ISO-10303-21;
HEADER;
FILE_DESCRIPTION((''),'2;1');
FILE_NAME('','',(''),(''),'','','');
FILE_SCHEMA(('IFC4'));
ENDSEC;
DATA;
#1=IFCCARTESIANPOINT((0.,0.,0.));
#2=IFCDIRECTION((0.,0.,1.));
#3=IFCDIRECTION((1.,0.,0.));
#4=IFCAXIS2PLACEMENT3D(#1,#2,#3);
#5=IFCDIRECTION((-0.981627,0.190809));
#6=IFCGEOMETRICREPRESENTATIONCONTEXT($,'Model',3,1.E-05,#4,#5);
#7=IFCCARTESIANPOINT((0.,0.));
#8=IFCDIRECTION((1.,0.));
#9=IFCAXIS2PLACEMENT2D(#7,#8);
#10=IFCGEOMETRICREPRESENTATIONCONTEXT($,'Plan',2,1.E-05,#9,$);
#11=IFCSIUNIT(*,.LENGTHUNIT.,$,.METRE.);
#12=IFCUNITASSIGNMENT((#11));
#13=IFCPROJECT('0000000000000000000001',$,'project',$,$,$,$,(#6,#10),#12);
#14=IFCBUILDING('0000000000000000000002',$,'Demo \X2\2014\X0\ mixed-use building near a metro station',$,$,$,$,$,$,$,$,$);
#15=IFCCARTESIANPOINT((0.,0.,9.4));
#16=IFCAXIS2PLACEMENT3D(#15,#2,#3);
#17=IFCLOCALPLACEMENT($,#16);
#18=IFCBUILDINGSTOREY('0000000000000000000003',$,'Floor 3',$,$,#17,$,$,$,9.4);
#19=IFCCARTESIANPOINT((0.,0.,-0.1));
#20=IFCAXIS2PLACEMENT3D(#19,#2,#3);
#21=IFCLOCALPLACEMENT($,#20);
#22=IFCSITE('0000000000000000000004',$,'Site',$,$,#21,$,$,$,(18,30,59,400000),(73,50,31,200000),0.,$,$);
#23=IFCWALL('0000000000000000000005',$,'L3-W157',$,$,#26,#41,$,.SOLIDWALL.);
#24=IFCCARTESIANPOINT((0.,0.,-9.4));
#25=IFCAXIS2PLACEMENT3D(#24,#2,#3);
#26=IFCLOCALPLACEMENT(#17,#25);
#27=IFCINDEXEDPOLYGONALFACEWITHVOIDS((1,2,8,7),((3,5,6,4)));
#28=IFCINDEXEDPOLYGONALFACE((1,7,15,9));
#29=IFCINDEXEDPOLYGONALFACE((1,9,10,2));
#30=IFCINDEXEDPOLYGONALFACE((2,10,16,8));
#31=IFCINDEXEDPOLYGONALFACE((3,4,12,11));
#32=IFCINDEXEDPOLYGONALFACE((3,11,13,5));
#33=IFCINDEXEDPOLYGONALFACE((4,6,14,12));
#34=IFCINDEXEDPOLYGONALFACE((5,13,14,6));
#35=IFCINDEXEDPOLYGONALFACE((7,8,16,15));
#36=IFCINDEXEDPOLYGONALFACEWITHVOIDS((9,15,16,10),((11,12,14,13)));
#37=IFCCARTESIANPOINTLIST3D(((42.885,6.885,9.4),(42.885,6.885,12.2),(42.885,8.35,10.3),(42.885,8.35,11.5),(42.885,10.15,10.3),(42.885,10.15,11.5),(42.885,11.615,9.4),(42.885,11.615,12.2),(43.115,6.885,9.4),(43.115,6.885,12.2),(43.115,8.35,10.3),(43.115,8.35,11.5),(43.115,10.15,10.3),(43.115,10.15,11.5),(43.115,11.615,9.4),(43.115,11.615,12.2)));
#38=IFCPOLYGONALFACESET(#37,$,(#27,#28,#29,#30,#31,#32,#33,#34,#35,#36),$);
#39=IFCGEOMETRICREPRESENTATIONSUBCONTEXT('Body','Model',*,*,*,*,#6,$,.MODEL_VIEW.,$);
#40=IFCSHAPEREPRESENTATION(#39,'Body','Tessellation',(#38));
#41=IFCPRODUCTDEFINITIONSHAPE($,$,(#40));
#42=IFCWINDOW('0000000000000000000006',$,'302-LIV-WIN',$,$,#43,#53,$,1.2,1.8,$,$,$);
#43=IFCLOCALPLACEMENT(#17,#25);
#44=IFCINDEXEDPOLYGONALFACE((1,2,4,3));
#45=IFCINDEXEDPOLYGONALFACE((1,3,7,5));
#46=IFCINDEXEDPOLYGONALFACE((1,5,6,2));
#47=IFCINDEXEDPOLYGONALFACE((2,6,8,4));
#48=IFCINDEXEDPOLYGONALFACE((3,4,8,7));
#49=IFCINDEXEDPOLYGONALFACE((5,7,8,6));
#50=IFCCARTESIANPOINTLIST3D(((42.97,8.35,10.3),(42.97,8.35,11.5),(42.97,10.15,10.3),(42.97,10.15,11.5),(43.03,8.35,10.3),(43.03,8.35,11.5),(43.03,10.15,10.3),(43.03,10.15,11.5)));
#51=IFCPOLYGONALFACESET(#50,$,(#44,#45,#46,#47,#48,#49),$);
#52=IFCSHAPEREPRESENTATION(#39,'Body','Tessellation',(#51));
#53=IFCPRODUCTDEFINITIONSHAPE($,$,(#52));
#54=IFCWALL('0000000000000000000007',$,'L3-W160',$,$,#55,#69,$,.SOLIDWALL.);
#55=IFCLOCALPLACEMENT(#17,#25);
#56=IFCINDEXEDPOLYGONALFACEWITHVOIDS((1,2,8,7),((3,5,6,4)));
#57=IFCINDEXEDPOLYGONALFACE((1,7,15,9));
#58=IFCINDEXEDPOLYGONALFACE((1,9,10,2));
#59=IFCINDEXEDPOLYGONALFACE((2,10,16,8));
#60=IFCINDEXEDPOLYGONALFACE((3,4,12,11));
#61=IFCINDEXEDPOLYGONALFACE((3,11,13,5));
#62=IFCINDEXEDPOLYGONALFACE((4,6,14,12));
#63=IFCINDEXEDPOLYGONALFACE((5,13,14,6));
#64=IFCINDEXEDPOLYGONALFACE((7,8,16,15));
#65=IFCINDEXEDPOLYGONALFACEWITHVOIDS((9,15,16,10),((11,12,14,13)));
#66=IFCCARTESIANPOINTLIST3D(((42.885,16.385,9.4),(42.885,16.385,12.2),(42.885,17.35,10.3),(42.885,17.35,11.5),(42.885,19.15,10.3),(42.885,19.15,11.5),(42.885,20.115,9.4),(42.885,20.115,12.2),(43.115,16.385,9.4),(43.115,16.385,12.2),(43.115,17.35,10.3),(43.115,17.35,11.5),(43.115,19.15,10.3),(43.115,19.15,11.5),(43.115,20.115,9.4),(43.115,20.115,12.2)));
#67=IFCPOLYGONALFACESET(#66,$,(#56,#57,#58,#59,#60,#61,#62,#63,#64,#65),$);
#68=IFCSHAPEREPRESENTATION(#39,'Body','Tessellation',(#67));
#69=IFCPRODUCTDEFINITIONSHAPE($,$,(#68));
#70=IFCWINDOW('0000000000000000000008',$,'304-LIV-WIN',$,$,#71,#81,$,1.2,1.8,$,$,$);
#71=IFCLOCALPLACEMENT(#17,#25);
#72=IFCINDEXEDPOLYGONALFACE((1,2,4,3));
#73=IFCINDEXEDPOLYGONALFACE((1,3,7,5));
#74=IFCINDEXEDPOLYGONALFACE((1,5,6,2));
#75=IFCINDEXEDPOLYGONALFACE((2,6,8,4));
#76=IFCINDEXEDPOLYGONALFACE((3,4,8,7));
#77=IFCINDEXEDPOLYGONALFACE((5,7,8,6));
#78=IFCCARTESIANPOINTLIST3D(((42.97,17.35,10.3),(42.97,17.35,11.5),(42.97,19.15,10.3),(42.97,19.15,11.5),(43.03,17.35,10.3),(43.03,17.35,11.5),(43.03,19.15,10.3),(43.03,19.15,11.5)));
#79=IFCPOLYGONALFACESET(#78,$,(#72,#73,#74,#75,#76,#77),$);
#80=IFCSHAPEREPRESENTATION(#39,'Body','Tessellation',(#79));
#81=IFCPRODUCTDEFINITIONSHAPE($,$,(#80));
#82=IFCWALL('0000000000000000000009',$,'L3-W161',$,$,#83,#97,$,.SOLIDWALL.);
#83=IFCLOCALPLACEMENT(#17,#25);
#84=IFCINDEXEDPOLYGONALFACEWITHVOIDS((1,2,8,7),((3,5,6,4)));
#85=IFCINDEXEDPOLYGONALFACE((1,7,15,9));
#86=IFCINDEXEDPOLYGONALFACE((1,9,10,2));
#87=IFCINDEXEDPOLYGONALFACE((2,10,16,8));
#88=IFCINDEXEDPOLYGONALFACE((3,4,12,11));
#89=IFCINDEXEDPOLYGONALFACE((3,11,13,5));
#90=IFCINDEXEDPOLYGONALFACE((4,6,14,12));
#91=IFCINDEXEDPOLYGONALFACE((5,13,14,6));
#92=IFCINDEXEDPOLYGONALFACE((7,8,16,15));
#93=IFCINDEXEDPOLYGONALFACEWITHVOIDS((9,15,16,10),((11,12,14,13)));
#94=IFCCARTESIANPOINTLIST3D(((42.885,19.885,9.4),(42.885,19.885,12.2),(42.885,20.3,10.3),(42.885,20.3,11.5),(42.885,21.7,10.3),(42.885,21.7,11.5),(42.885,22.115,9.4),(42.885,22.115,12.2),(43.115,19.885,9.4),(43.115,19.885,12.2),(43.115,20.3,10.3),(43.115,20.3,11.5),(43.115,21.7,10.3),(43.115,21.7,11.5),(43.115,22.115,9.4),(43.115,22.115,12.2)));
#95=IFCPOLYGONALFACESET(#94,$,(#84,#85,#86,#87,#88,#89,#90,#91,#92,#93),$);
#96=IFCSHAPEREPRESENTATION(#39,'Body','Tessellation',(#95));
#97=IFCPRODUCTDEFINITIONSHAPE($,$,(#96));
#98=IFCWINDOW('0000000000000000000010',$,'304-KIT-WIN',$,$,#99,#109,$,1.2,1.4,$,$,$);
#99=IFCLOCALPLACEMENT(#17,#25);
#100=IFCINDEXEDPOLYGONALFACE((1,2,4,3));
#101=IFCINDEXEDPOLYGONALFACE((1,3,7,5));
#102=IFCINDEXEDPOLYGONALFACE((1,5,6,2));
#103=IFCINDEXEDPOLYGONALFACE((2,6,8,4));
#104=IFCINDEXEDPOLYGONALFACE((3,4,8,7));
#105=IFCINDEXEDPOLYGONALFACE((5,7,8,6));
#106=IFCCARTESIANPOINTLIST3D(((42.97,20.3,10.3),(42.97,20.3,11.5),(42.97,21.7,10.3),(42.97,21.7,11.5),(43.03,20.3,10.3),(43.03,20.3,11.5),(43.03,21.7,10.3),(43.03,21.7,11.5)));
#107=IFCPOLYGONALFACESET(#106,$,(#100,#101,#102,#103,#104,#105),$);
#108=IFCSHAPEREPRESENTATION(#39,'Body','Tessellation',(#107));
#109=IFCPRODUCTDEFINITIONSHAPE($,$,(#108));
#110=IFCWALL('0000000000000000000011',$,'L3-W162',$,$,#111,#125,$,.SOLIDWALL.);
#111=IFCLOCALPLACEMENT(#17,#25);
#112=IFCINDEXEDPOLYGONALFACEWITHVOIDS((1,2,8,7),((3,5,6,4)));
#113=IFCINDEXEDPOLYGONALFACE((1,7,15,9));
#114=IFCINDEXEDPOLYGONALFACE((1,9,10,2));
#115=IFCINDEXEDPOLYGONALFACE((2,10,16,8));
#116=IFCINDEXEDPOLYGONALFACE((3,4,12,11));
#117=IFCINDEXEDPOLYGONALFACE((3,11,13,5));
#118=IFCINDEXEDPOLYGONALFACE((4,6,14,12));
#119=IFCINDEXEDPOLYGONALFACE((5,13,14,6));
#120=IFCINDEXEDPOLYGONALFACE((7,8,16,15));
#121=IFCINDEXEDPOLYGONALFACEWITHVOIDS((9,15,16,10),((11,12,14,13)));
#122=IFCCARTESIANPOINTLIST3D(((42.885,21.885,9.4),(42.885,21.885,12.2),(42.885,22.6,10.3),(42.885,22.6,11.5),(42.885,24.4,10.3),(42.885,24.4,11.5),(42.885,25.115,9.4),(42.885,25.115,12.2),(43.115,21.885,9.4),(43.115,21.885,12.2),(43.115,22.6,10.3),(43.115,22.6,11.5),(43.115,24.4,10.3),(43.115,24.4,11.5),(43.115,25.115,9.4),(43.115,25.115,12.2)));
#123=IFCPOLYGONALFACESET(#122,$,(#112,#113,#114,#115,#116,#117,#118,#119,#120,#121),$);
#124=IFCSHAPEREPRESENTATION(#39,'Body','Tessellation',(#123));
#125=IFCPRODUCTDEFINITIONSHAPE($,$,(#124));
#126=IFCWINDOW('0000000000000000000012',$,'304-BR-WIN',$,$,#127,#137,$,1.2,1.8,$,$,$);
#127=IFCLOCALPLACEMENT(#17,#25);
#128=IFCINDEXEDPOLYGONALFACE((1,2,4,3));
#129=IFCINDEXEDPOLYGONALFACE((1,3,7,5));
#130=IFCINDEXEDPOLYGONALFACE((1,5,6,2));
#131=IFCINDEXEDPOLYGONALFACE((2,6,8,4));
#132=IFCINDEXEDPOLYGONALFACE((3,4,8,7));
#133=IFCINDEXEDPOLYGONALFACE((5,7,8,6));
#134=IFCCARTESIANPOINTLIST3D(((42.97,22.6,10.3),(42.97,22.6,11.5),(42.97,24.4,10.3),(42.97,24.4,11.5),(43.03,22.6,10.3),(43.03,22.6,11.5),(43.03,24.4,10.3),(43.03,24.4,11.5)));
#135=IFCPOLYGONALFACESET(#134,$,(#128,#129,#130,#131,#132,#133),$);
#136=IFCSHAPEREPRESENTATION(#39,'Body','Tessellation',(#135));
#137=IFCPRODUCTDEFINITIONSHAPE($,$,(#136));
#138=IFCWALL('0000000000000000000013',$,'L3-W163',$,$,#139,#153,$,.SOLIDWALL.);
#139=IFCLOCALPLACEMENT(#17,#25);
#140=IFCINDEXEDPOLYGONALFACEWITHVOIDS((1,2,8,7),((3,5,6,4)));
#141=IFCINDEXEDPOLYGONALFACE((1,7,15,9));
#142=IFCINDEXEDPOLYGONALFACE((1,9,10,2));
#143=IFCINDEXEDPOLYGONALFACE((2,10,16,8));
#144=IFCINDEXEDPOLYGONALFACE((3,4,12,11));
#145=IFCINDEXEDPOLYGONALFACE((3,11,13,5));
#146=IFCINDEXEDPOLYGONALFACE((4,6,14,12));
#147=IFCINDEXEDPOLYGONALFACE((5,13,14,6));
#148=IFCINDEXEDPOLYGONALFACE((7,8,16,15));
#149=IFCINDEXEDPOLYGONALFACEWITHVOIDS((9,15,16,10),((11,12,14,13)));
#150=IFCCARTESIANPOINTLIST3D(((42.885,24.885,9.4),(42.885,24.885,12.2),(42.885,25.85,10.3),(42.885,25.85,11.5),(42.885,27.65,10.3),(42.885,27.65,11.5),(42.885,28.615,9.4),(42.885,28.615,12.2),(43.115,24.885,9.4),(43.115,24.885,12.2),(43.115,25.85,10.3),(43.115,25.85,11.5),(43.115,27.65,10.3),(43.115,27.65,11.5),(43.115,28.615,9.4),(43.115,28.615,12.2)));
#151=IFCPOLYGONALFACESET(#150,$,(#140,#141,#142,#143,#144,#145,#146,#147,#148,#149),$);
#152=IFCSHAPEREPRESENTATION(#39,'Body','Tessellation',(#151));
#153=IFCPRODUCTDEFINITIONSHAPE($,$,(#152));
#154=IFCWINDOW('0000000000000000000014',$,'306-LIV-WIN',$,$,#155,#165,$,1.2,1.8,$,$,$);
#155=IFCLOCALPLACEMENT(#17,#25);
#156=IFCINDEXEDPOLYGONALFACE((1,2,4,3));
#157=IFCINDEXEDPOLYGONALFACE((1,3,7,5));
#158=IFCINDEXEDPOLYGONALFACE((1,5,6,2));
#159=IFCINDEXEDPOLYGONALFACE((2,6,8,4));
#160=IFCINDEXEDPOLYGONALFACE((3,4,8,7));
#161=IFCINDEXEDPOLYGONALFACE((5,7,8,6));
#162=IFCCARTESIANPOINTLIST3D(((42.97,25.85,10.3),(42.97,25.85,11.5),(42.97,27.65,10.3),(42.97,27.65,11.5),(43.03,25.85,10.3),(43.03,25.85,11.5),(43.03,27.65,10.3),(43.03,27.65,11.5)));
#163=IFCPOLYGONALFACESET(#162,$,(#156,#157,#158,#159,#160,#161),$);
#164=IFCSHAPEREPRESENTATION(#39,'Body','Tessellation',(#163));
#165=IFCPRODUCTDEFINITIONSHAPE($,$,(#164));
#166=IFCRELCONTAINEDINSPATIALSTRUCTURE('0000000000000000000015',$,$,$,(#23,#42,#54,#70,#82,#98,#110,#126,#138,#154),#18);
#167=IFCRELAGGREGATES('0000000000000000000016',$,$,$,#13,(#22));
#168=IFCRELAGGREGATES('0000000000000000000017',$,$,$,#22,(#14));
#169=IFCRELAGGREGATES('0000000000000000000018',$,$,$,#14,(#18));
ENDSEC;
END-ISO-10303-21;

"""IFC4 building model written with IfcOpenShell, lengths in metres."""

from ifc_helpers import new_model, si_unit, direction, frame, origin_with_axes, origin_2d_with_axis, place, context, subcontext, project, spatial, line, indexed_curve, outline, extrude, element, fill, save


model = new_model("IFC4")

# Units and contexts
model_context = context("Model", 3, precision=1e-05, world=origin_with_axes(), true_north=direction((-0.981627, 0.190809)))
plan_context = context("Plan", 2, precision=1e-05, world=origin_2d_with_axis())
body_context = subcontext(model_context, "Body", "Model", "MODEL_VIEW")
ifc_project = project(units=[si_unit("LENGTHUNIT", "METRE")], contexts=[model_context, plan_context])

# Site, building, storey
site_placement = place(None, frame((0.0, 0.0, -0.1), z_axis=(0.0, 0.0, 1.0), x_axis=(1.0, 0.0, 0.0)))
site = spatial("IfcSite", under=ifc_project, at=site_placement, Name="Site", RefLatitude=(18, 30, 59, 400000), RefLongitude=(73, 50, 31, 200000), RefElevation=0.0)
building = spatial("IfcBuilding", under=site, Name="Demo — mixed-use building near a metro station")
storey_placement = place(None, frame((0.0, 0.0, 9.4), z_axis=(0.0, 0.0, 1.0), x_axis=(1.0, 0.0, 0.0)))
storey = spatial("IfcBuildingStorey", under=building, at=storey_placement, Name="Floor 3", Elevation=9.4)

# Wall, opening, window
wall_1_placement = place(storey_placement, frame((0.0, 0.0, -9.4), z_axis=(0.0, 0.0, 1.0), x_axis=(1.0, 0.0, 0.0)))
wall_1 = element("IfcWall", 1, at=wall_1_placement, inside=storey, Name="L3-W157", PredefinedType="SOLIDWALL", context=body_context, shape_type="SweptSolid", body=[
    extrude(outline(indexed_curve([(42.885, 6.885), (42.885, 11.615), (43.115, 11.615), (43.115, 6.885)], segments=[line(1, 2, 3, 4, 1)])), frame((0.0, 0.0, 9.4), z_axis=(0.0, 0.0, 1.0), x_axis=(1.0, 0.0, 0.0)), (0.0, 0.0, 1.0), 2.8),
])
opening_1_placement = place(wall_1_placement, origin_with_axes())
opening_1 = element("IfcOpeningElement", 2, at=opening_1_placement, cuts=wall_1, context=body_context, shape_type="SweptSolid", body=[
    extrude(outline(indexed_curve([(42.835, 8.35), (42.835, 10.15), (43.165, 10.15), (43.165, 8.35)], segments=[line(1, 2, 3, 4, 1)])), frame((0.0, 0.0, 10.3), z_axis=(0.0, 0.0, 1.0), x_axis=(1.0, 0.0, 0.0)), (0.0, 0.0, 1.0), 1.2),
])
window_1_placement = place(storey_placement, frame((0.0, 0.0, -9.4), z_axis=(0.0, 0.0, 1.0), x_axis=(1.0, 0.0, 0.0)))
window_1 = element("IfcWindow", 3, at=window_1_placement, inside=storey, Name="302-LIV-WIN", OverallHeight=1.2, OverallWidth=1.8, context=body_context, shape_type="SweptSolid", body=[
    extrude(outline(indexed_curve([(42.97, 8.35), (42.97, 10.15), (43.03, 10.15), (43.03, 8.35)], segments=[line(1, 2, 3, 4, 1)])), frame((0.0, 0.0, 10.3), z_axis=(0.0, 0.0, 1.0), x_axis=(1.0, 0.0, 0.0)), (0.0, 0.0, 1.0), 1.2),
])
fill(opening_1, window_1)

# Walls, openings, windows
wall_2_placement = place(storey_placement, frame((0.0, 0.0, -9.4), z_axis=(0.0, 0.0, 1.0), x_axis=(1.0, 0.0, 0.0)))
wall_2 = element("IfcWall", 4, at=wall_2_placement, inside=storey, Name="L3-W160", PredefinedType="SOLIDWALL", context=body_context, shape_type="SweptSolid", body=[
    extrude(outline(indexed_curve([(42.885, 16.385), (42.885, 20.115), (43.115, 20.115), (43.115, 16.385)], segments=[line(1, 2, 3, 4, 1)])), frame((0.0, 0.0, 9.4), z_axis=(0.0, 0.0, 1.0), x_axis=(1.0, 0.0, 0.0)), (0.0, 0.0, 1.0), 2.8),
])
opening_2_placement = place(wall_2_placement, origin_with_axes())
opening_2 = element("IfcOpeningElement", 5, at=opening_2_placement, cuts=wall_2, context=body_context, shape_type="SweptSolid", body=[
    extrude(outline(indexed_curve([(42.835, 17.35), (42.835, 19.15), (43.165, 19.15), (43.165, 17.35)], segments=[line(1, 2, 3, 4, 1)])), frame((0.0, 0.0, 10.3), z_axis=(0.0, 0.0, 1.0), x_axis=(1.0, 0.0, 0.0)), (0.0, 0.0, 1.0), 1.2),
])
window_2_placement = place(storey_placement, frame((0.0, 0.0, -9.4), z_axis=(0.0, 0.0, 1.0), x_axis=(1.0, 0.0, 0.0)))
window_2 = element("IfcWindow", 6, at=window_2_placement, inside=storey, Name="304-LIV-WIN", OverallHeight=1.2, OverallWidth=1.8, context=body_context, shape_type="SweptSolid", body=[
    extrude(outline(indexed_curve([(42.97, 17.35), (42.97, 19.15), (43.03, 19.15), (43.03, 17.35)], segments=[line(1, 2, 3, 4, 1)])), frame((0.0, 0.0, 10.3), z_axis=(0.0, 0.0, 1.0), x_axis=(1.0, 0.0, 0.0)), (0.0, 0.0, 1.0), 1.2),
])
fill(opening_2, window_2)
wall_3_placement = place(storey_placement, frame((0.0, 0.0, -9.4), z_axis=(0.0, 0.0, 1.0), x_axis=(1.0, 0.0, 0.0)))
wall_3 = element("IfcWall", 7, at=wall_3_placement, inside=storey, Name="L3-W161", PredefinedType="SOLIDWALL", context=body_context, shape_type="SweptSolid", body=[
    extrude(outline(indexed_curve([(42.885, 19.885), (42.885, 22.115), (43.115, 22.115), (43.115, 19.885)], segments=[line(1, 2, 3, 4, 1)])), frame((0.0, 0.0, 9.4), z_axis=(0.0, 0.0, 1.0), x_axis=(1.0, 0.0, 0.0)), (0.0, 0.0, 1.0), 2.8),
])
opening_3_placement = place(wall_3_placement, origin_with_axes())
opening_3 = element("IfcOpeningElement", 8, at=opening_3_placement, cuts=wall_3, context=body_context, shape_type="SweptSolid", body=[
    extrude(outline(indexed_curve([(42.835, 20.3), (42.835, 21.7), (43.165, 21.7), (43.165, 20.3)], segments=[line(1, 2, 3, 4, 1)])), frame((0.0, 0.0, 10.3), z_axis=(0.0, 0.0, 1.0), x_axis=(1.0, 0.0, 0.0)), (0.0, 0.0, 1.0), 1.2),
])
window_3_placement = place(storey_placement, frame((0.0, 0.0, -9.4), z_axis=(0.0, 0.0, 1.0), x_axis=(1.0, 0.0, 0.0)))
window_3 = element("IfcWindow", 9, at=window_3_placement, inside=storey, Name="304-KIT-WIN", OverallHeight=1.2, OverallWidth=1.4, context=body_context, shape_type="SweptSolid", body=[
    extrude(outline(indexed_curve([(42.97, 20.3), (42.97, 21.7), (43.03, 21.7), (43.03, 20.3)], segments=[line(1, 2, 3, 4, 1)])), frame((0.0, 0.0, 10.3), z_axis=(0.0, 0.0, 1.0), x_axis=(1.0, 0.0, 0.0)), (0.0, 0.0, 1.0), 1.2),
])
fill(opening_3, window_3)
wall_4_placement = place(storey_placement, frame((0.0, 0.0, -9.4), z_axis=(0.0, 0.0, 1.0), x_axis=(1.0, 0.0, 0.0)))
wall_4 = element("IfcWall", 10, at=wall_4_placement, inside=storey, Name="L3-W162", PredefinedType="SOLIDWALL", context=body_context, shape_type="SweptSolid", body=[
    extrude(outline(indexed_curve([(42.885, 21.885), (42.885, 25.115), (43.115, 25.115), (43.115, 21.885)], segments=[line(1, 2, 3, 4, 1)])), frame((0.0, 0.0, 9.4), z_axis=(0.0, 0.0, 1.0), x_axis=(1.0, 0.0, 0.0)), (0.0, 0.0, 1.0), 2.8),
])
opening_4_placement = place(wall_4_placement, origin_with_axes())
opening_4 = element("IfcOpeningElement", 11, at=opening_4_placement, cuts=wall_4, context=body_context, shape_type="SweptSolid", body=[
    extrude(outline(indexed_curve([(42.835, 22.6), (42.835, 24.4), (43.165, 24.4), (43.165, 22.6)], segments=[line(1, 2, 3, 4, 1)])), frame((0.0, 0.0, 10.3), z_axis=(0.0, 0.0, 1.0), x_axis=(1.0, 0.0, 0.0)), (0.0, 0.0, 1.0), 1.2),
])
window_4_placement = place(storey_placement, frame((0.0, 0.0, -9.4), z_axis=(0.0, 0.0, 1.0), x_axis=(1.0, 0.0, 0.0)))
window_4 = element("IfcWindow", 12, at=window_4_placement, inside=storey, Name="304-BR-WIN", OverallHeight=1.2, OverallWidth=1.8, context=body_context, shape_type="SweptSolid", body=[
    extrude(outline(indexed_curve([(42.97, 22.6), (42.97, 24.4), (43.03, 24.4), (43.03, 22.6)], segments=[line(1, 2, 3, 4, 1)])), frame((0.0, 0.0, 10.3), z_axis=(0.0, 0.0, 1.0), x_axis=(1.0, 0.0, 0.0)), (0.0, 0.0, 1.0), 1.2),
])
fill(opening_4, window_4)
wall_5_placement = place(storey_placement, frame((0.0, 0.0, -9.4), z_axis=(0.0, 0.0, 1.0), x_axis=(1.0, 0.0, 0.0)))
wall_5 = element("IfcWall", 13, at=wall_5_placement, inside=storey, Name="L3-W163", PredefinedType="SOLIDWALL", context=body_context, shape_type="SweptSolid", body=[
    extrude(outline(indexed_curve([(42.885, 24.885), (42.885, 28.615), (43.115, 28.615), (43.115, 24.885)], segments=[line(1, 2, 3, 4, 1)])), frame((0.0, 0.0, 9.4), z_axis=(0.0, 0.0, 1.0), x_axis=(1.0, 0.0, 0.0)), (0.0, 0.0, 1.0), 2.8),
])
opening_5_placement = place(wall_5_placement, origin_with_axes())
opening_5 = element("IfcOpeningElement", 14, at=opening_5_placement, cuts=wall_5, context=body_context, shape_type="SweptSolid", body=[
    extrude(outline(indexed_curve([(42.835, 25.85), (42.835, 27.65), (43.165, 27.65), (43.165, 25.85)], segments=[line(1, 2, 3, 4, 1)])), frame((0.0, 0.0, 10.3), z_axis=(0.0, 0.0, 1.0), x_axis=(1.0, 0.0, 0.0)), (0.0, 0.0, 1.0), 1.2),
])
window_5_placement = place(storey_placement, frame((0.0, 0.0, -9.4), z_axis=(0.0, 0.0, 1.0), x_axis=(1.0, 0.0, 0.0)))
window_5 = element("IfcWindow", 15, at=window_5_placement, inside=storey, Name="306-LIV-WIN", OverallHeight=1.2, OverallWidth=1.8, context=body_context, shape_type="SweptSolid", body=[
    extrude(outline(indexed_curve([(42.97, 25.85), (42.97, 27.65), (43.03, 27.65), (43.03, 25.85)], segments=[line(1, 2, 3, 4, 1)])), frame((0.0, 0.0, 10.3), z_axis=(0.0, 0.0, 1.0), x_axis=(1.0, 0.0, 0.0)), (0.0, 0.0, 1.0), 1.2),
])
fill(opening_5, window_5)

save(model, "model.ifc")
